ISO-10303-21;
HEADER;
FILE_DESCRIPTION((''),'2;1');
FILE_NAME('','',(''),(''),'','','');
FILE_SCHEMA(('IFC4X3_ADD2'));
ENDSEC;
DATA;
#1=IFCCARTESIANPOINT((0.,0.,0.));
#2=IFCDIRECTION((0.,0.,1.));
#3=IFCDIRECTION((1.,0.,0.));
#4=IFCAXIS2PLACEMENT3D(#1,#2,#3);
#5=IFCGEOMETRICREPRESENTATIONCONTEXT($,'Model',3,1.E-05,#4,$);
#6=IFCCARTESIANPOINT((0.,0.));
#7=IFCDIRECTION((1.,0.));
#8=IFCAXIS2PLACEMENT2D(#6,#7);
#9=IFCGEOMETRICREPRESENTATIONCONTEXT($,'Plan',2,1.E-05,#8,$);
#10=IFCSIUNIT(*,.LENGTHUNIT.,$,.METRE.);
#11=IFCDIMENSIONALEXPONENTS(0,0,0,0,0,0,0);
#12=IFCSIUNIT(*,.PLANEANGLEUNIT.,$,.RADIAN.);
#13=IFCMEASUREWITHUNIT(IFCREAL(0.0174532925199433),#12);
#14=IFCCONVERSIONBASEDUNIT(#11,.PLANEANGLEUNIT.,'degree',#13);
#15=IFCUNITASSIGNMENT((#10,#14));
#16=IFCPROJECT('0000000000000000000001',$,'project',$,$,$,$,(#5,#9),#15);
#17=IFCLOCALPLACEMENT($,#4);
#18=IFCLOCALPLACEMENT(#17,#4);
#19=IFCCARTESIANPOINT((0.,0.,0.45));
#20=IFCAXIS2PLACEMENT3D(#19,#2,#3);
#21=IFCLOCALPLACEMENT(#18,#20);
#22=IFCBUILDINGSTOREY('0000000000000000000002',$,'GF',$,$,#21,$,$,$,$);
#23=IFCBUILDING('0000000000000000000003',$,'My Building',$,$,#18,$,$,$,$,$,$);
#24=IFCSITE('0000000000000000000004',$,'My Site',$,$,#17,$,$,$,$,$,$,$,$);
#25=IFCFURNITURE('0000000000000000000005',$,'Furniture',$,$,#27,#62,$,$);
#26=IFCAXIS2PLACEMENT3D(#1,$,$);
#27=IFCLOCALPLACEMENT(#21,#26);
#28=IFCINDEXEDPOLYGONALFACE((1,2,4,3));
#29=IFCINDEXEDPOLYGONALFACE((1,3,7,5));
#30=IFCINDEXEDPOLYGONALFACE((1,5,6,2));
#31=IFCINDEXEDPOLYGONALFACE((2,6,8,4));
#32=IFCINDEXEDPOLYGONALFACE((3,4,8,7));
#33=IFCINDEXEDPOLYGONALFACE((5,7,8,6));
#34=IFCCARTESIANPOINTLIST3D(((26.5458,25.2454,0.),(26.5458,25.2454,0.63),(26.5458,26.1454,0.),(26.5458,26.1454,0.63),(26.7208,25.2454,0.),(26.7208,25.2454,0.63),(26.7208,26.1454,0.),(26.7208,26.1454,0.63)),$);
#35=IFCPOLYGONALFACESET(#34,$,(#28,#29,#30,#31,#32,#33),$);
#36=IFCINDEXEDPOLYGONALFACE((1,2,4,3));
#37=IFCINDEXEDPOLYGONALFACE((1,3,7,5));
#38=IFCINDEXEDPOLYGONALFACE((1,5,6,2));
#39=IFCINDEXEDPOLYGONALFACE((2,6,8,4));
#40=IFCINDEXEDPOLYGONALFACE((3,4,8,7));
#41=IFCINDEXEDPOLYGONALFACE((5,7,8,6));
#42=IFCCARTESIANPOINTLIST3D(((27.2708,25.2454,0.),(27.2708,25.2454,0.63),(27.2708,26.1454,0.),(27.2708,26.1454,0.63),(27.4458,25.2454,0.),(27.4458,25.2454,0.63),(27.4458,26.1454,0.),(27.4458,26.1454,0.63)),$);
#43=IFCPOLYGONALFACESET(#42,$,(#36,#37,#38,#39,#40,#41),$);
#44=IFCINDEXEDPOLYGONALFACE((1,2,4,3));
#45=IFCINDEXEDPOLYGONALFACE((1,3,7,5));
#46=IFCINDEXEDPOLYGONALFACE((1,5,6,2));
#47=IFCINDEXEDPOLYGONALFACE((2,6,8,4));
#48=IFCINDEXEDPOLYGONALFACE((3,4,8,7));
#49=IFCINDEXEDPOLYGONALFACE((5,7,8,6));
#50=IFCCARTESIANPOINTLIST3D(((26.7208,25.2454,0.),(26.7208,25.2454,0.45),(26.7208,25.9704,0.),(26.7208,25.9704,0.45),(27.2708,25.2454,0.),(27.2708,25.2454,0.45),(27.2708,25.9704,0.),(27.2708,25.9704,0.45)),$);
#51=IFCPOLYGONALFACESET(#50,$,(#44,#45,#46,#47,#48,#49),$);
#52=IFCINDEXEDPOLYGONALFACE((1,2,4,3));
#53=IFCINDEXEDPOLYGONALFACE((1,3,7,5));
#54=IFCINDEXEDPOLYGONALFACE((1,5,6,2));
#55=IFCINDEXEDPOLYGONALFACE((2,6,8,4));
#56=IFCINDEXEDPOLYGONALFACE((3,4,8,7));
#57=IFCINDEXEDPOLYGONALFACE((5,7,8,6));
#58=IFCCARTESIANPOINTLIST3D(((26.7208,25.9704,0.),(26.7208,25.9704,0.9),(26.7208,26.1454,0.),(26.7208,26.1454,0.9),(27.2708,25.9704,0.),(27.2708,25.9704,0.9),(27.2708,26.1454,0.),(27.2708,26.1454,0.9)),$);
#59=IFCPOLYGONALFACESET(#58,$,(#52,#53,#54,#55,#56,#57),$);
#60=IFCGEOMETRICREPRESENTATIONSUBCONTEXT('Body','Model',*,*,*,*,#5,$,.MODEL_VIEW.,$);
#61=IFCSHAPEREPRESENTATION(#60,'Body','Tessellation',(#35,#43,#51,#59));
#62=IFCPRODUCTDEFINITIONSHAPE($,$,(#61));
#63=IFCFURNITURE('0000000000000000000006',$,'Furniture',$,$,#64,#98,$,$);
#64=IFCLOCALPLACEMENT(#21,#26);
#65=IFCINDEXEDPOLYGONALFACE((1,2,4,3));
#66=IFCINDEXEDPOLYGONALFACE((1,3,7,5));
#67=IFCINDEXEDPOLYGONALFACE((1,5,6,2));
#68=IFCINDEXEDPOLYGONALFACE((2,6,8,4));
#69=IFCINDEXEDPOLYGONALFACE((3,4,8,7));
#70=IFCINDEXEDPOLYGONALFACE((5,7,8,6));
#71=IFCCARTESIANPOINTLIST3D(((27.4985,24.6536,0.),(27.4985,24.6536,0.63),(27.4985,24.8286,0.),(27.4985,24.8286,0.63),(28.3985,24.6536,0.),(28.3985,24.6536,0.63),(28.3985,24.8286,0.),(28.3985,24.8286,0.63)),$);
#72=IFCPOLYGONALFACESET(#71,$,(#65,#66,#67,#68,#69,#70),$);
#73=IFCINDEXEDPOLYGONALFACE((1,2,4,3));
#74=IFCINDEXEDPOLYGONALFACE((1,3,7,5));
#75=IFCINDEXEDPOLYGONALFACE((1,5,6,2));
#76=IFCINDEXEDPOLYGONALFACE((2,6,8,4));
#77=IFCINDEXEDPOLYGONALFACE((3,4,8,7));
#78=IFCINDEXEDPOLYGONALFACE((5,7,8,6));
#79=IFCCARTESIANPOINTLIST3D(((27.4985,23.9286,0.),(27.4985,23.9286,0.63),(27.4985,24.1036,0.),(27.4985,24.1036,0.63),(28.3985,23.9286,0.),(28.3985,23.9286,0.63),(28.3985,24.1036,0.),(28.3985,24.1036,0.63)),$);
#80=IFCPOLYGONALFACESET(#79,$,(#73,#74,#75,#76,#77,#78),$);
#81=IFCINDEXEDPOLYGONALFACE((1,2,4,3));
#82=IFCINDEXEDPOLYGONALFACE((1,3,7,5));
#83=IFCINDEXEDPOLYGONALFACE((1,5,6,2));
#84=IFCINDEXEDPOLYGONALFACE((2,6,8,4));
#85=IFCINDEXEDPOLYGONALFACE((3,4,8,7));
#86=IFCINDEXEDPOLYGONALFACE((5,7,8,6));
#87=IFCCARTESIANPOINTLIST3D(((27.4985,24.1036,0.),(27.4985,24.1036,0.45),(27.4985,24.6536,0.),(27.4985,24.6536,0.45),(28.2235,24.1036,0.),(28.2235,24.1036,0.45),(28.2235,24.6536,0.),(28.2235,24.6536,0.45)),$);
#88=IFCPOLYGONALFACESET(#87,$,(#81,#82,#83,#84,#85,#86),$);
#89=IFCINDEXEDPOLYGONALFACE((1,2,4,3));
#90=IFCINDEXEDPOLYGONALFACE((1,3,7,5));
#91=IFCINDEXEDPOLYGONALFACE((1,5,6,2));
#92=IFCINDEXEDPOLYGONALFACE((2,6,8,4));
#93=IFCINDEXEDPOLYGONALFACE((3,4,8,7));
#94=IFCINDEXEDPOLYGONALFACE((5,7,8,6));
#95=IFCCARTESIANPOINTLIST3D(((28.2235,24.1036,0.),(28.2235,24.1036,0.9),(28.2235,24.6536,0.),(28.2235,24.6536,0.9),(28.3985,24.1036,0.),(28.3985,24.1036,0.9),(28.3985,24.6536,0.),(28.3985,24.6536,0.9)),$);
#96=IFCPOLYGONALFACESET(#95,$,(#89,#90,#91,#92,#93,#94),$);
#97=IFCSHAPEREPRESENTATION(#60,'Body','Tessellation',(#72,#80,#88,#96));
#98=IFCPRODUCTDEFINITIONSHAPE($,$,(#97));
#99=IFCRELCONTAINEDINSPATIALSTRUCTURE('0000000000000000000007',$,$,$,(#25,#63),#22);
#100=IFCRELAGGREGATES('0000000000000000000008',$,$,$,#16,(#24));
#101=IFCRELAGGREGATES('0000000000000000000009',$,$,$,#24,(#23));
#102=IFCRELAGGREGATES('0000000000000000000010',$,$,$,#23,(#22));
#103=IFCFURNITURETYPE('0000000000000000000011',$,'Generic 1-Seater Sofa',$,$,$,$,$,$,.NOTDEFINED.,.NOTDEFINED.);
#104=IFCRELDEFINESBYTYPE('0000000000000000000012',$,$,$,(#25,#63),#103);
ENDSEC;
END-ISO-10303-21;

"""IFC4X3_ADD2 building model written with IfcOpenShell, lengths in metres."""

from ifc_helpers import new_model, entity, si_unit, converted_unit, frame, origin_with_axes, origin_2d_with_axis, place, context, subcontext, project, spatial, line, indexed_curve, outline, extrude, shape, source, transform, mapped, type_object, type_shapes, element, save


model = new_model("IFC4X3_ADD2")

# Units and contexts
model_context = context("Model", 3, precision=1e-05, world=origin_with_axes())
plan_context = context("Plan", 2, precision=1e-05, world=origin_2d_with_axis())
body_context_1 = subcontext(model_context, "Body", "Model", "MODEL_VIEW")
body_context_2 = subcontext(plan_context, "Body", "Plan", "PLAN_VIEW")
ifc_project = project(units=[si_unit("LENGTHUNIT", "METRE"), converted_unit("PLANEANGLEUNIT", "degree", entity("IfcReal", 0.0174532925199433), si_unit("PLANEANGLEUNIT", "RADIAN"), dimensions=[0, 0, 0, 0, 0, 0, 0])], contexts=[model_context, plan_context])

# Site, building, storey
site_placement = place(None, origin_with_axes())
site = spatial("IfcSite", under=ifc_project, at=site_placement, Name="My Site")
building_placement = place(site_placement, origin_with_axes())
building = spatial("IfcBuilding", under=site, at=building_placement, Name="My Building")
storey_placement = place(building_placement, frame((0.0, 0.0, 0.45), z_axis=(0.0, 0.0, 1.0), x_axis=(1.0, 0.0, 0.0)))
storey = spatial("IfcBuildingStorey", under=building, at=storey_placement, Name="GF")

# Furniture
furniture_type_1 = type_object("IfcFurnitureType", Name="Generic 1-Seater Sofa", AssemblyPlace="NOTDEFINED", PredefinedType="NOTDEFINED")
shared_shape_1 = source(origin_with_axes(), body_context_1, "Body", "SweptSolid", [
    extrude(outline(indexed_curve([(0.0, 0.0), (0.175, 0.0), (0.175, 0.9), (0.0, 0.9)], segments=[line(1, 2, 3, 4, 1)])), frame((-0.45, -0.9, 0.0), z_axis=(0.0, 0.0, 1.0), x_axis=(1.0, 0.0, 0.0)), (0.0, 0.0, 1.0), 0.63),
    extrude(outline(indexed_curve([(0.0, 0.0), (0.175, 0.0), (0.175, 0.9), (0.0, 0.9)], segments=[line(1, 2, 3, 4, 1)])), frame((0.275, -0.9, 0.0), z_axis=(0.0, 0.0, 1.0), x_axis=(1.0, 0.0, 0.0)), (0.0, 0.0, 1.0), 0.63),
    extrude(outline(indexed_curve([(0.175, 0.0), (0.725, 0.0), (0.725, 0.725), (0.175, 0.725)], segments=[line(1, 2, 3, 4, 1)])), frame((-0.45, -0.9, 0.0), z_axis=(0.0, 0.0, 1.0), x_axis=(1.0, 0.0, 0.0)), (0.0, 0.0, 1.0), 0.45),
    extrude(outline(indexed_curve([(0.175, 0.725), (0.725, 0.725), (0.725, 0.9), (0.175, 0.9)], segments=[line(1, 2, 3, 4, 1)])), frame((-0.45, -0.9, 0.0), z_axis=(0.0, 0.0, 1.0), x_axis=(1.0, 0.0, 0.0)), (0.0, 0.0, 1.0), 0.9),
])
shared_shape_2 = source(origin_with_axes(), body_context_2, "Body", "Annotation2D", [
    entity("IfcGeometricCurveSet", [entity("IfcIndexedPolyCurve", entity("IfcCartesianPointList2D", [[0.275, -0.175], [0.275, -0.9], [0.45, -0.9], [0.45, 0.0], [0.275, 0.0], [0.275, -0.9], [-0.275, -0.9], [-0.275, 0.0], [-0.275, -0.175], [0.275, -0.175], [0.275, 0.0], [-0.275, 0.0], [-0.45, 0.0], [-0.45, -0.9], [-0.275, -0.9], [-0.275, -0.175]]))]),
])
type_shapes(furniture_type_1, [shared_shape_1, shared_shape_2])
for number, where, z_axis, x_axis, name in (
    (1, (26.9958, 26.1454, 0.0), (0.0, 0.0, 1.0), (1.0, 0.0, 0.0), "Furniture"),
    (2, (28.3985, 24.3786, 0.0), (0.0, 0.0, 1.0), (0.0, -1.0, 0.0), "Furniture"),
):
    element("IfcFurniture", number, at=place(storey_placement, frame(where, z_axis=z_axis, x_axis=x_axis)), inside=storey, type_object=furniture_type_1, Name=name, shapes=[
        shape(body_context_1, "Body", "MappedRepresentation", [mapped(shared_shape_1, transform((0.0, 0.0, 0.0), x_axis=(1.0, 0.0, 0.0), y_axis=(0.0, 1.0, 0.0), z_axis=(0.0, 0.0, 1.0), scale=1.0))]),
        shape(body_context_2, "Body", "MappedRepresentation", [mapped(shared_shape_2, transform((0.0, 0.0, 0.0), x_axis=(1.0, 0.0, 0.0), y_axis=(0.0, 1.0, 0.0), z_axis=(0.0, 0.0, 1.0), scale=1.0))]),
    ])

save(model, "model.ifc")
